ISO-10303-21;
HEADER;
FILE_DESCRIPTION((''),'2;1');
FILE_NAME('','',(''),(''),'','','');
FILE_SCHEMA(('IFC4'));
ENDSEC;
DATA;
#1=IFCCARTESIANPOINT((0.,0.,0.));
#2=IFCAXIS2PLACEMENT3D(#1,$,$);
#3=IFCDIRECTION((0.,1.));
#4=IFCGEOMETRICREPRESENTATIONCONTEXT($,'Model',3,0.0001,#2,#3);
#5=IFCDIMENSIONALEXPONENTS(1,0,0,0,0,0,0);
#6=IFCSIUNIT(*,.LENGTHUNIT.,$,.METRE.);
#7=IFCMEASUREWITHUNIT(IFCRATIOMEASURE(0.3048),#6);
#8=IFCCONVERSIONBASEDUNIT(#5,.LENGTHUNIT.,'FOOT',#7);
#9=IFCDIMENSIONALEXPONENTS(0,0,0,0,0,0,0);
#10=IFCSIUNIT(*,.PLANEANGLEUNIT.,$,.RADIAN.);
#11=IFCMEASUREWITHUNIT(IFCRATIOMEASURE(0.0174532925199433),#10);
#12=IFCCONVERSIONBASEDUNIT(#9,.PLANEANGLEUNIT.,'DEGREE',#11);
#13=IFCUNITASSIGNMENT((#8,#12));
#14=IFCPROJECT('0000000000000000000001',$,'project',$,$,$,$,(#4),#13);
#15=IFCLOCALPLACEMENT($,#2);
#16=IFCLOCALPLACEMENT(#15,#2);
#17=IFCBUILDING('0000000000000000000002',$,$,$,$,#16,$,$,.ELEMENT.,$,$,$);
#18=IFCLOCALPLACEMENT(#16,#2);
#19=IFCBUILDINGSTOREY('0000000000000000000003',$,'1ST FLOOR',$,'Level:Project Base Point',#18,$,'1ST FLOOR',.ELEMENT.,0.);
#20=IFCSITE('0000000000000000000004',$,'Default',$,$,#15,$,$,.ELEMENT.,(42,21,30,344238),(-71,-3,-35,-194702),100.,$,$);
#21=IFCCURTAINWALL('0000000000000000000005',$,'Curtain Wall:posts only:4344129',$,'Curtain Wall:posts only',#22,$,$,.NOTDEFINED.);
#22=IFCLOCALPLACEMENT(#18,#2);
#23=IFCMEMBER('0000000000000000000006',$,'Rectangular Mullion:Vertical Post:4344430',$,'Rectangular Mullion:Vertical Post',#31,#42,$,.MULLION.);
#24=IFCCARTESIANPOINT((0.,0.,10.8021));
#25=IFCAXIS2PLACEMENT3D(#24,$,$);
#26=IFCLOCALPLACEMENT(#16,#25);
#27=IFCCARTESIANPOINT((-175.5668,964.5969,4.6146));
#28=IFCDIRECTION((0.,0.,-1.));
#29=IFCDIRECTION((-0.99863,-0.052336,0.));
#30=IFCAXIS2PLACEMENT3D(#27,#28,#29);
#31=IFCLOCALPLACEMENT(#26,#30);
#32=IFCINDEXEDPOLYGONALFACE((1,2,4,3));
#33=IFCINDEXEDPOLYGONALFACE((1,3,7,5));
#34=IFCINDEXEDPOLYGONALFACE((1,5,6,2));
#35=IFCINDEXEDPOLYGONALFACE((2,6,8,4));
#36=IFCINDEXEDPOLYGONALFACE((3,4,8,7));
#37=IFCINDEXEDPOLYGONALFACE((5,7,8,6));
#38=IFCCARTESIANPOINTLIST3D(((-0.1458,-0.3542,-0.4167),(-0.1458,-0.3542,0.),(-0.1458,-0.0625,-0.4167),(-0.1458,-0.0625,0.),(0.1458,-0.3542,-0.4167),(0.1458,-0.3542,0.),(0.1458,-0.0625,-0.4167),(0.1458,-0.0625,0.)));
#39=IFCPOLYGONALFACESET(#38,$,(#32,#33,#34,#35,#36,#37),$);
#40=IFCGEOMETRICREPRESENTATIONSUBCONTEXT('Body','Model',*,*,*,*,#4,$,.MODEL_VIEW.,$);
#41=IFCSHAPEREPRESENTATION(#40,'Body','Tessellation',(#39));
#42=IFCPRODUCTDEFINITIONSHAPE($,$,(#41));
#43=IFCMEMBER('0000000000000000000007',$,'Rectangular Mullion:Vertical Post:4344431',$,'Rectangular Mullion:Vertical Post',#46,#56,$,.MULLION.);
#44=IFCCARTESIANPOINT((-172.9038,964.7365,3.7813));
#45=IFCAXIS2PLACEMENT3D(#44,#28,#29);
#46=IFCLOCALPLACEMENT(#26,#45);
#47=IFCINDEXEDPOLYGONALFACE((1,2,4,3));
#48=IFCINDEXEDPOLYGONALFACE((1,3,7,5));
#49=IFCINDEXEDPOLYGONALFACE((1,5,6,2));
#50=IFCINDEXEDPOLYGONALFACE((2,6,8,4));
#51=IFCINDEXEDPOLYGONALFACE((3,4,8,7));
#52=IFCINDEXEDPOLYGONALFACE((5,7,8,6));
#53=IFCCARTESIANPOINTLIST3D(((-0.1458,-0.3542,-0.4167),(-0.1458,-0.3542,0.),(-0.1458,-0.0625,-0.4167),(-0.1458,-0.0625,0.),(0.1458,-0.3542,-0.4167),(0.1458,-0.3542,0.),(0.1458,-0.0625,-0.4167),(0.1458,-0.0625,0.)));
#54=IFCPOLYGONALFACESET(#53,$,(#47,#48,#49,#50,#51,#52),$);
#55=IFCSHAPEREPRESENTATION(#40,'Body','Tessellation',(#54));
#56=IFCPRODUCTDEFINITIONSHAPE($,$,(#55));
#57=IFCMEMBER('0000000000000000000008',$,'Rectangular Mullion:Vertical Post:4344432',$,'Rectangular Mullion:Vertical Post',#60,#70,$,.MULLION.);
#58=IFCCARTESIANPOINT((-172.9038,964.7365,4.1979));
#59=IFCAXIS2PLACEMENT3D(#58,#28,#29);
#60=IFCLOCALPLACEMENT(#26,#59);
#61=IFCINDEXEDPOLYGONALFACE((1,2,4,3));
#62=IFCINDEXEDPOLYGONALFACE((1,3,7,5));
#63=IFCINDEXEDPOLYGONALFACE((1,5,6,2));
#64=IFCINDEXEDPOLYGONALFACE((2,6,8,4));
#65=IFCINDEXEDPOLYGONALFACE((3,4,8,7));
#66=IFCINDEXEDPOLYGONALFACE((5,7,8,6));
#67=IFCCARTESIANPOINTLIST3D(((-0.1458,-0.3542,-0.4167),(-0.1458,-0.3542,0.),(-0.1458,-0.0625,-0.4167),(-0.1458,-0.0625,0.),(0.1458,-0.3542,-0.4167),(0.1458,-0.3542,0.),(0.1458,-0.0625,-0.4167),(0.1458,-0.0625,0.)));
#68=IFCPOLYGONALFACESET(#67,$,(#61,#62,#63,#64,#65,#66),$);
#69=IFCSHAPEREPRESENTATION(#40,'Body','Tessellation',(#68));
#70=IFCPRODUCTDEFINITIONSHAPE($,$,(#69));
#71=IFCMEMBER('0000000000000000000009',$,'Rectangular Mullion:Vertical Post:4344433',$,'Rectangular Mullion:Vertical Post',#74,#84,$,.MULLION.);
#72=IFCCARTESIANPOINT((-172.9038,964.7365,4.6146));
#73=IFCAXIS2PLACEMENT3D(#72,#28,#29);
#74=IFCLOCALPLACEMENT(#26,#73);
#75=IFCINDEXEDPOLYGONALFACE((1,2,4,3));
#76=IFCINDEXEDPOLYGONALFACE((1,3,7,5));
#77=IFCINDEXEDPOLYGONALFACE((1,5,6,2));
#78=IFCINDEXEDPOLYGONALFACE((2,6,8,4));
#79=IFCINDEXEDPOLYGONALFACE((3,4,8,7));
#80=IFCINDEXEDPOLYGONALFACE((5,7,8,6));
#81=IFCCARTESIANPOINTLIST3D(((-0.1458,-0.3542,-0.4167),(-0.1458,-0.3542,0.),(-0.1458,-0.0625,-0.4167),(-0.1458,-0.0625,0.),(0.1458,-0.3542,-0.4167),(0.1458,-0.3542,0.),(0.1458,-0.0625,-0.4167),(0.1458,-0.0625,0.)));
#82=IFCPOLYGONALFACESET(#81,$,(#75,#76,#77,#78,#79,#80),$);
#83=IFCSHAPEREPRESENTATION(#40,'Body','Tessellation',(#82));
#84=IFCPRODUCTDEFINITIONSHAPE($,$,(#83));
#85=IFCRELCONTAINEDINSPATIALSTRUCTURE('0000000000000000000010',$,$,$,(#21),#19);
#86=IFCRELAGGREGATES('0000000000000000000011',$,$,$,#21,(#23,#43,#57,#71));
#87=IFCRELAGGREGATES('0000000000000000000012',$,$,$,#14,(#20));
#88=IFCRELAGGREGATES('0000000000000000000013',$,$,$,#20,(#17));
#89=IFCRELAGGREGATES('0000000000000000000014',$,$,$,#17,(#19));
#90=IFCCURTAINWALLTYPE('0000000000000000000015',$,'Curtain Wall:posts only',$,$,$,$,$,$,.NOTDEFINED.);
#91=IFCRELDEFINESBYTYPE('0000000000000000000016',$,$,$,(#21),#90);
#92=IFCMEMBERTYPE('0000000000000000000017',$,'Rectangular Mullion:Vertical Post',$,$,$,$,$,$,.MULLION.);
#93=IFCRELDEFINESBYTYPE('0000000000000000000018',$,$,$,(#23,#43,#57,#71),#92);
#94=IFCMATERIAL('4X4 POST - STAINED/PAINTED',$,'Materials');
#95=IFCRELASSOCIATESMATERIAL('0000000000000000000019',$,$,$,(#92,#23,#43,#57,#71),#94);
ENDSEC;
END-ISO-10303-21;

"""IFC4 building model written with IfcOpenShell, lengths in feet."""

from ifc_helpers import new_model, entity, si_unit, converted_unit, direction, frame, origin, origin_2d_with_axis, place, context, subcontext, project, spatial, rectangle, extrude, source, transform, mapped, material, material_profile, profile_set, profile_usage, type_object, type_shapes, element, aggregate, save


model = new_model("IFC4")

# Units and contexts
model_context = context("Model", 3, precision=0.0001, world=origin(), true_north=direction((0.0, 1.0)))
body_context = subcontext(model_context, "Body", "Model", "MODEL_VIEW")
ifc_project = project(units=[converted_unit("LENGTHUNIT", "FOOT", entity("IfcRatioMeasure", 0.3048), si_unit("LENGTHUNIT", "METRE"), dimensions=[1, 0, 0, 0, 0, 0, 0]), converted_unit("PLANEANGLEUNIT", "DEGREE", entity("IfcRatioMeasure", 0.0174532925199433), si_unit("PLANEANGLEUNIT", "RADIAN"), dimensions=[0, 0, 0, 0, 0, 0, 0])], contexts=[model_context])

# Site, building, storey
site_placement = place(None, origin())
site = spatial("IfcSite", under=ifc_project, at=site_placement, Name="Default", CompositionType="ELEMENT", RefLatitude=(42, 21, 30, 344238), RefLongitude=(-71, -3, -35, -194702), RefElevation=100.0)
building_placement = place(site_placement, origin())
building = spatial("IfcBuilding", under=site, at=building_placement, CompositionType="ELEMENT")
storey_placement = place(building_placement, origin())
storey = spatial("IfcBuildingStorey", under=building, at=storey_placement, Name="1ST FLOOR", ObjectType="Level:Project Base Point", LongName="1ST FLOOR", CompositionType="ELEMENT", Elevation=0.0)

# Curtain wall, members
curtain_wall_type_1 = type_object("IfcCurtainWallType", Name="Curtain Wall:posts only", PredefinedType="NOTDEFINED")
curtain_wall_1_placement = place(storey_placement, origin())
curtain_wall_1 = element("IfcCurtainWall", 1, at=curtain_wall_1_placement, inside=storey, type_object=curtain_wall_type_1, Name="Curtain Wall:posts only:4344129", ObjectType="Curtain Wall:posts only", PredefinedType="NOTDEFINED")
ifc_material_1 = material(Name="4X4 POST - STAINED/PAINTED", Category="Materials")
ifc_material_profile_1 = material_profile(ifc_material_1, rectangle(XDim=0.2917, YDim=0.2917, at=origin_2d_with_axis()), Name="Vertical Post")
ifc_profile_set_1 = profile_set([ifc_material_profile_1], Name="Vertical Post")
ifc_profile_usage_1 = profile_usage(ifc_profile_set_1)
member_type_1 = type_object("IfcMemberType", Name="Rectangular Mullion:Vertical Post", PredefinedType="MULLION", material=ifc_profile_set_1)
shared_shape_1 = source(origin(), body_context, "Body", "SweptSolid", [
    extrude(rectangle(XDim=0.2917, YDim=0.2917, at=origin_2d_with_axis()), frame((0.0, -0.2083, -0.4167), z_axis=(0.0, 0.0, 1.0), x_axis=(0.0, -1.0, 0.0)), (0.0, 0.0, 1.0), 0.4167),
])
type_shapes(member_type_1, [shared_shape_1])
placement = place(building_placement, frame((0.0, 0.0, 10.8021)))
member_1_placement = place(placement, frame((-175.5668, 964.5969, 4.6146), z_axis=(0.0, 0.0, -1.0), x_axis=(-0.99863, -0.052336, 0.0)))
member_1 = element("IfcMember", 2, at=member_1_placement, type_object=member_type_1, material=ifc_profile_usage_1, Name="Rectangular Mullion:Vertical Post:4344430", ObjectType="Rectangular Mullion:Vertical Post", PredefinedType="MULLION", context=body_context, shape_type="MappedRepresentation", body=[
    mapped(shared_shape_1, transform((0.0, 0.0, 0.0), scale=1.0)),
])
ifc_profile_usage_2 = profile_usage(ifc_profile_set_1)
member_2_placement = place(placement, frame((-172.9038, 964.7365, 3.7813), z_axis=(0.0, 0.0, -1.0), x_axis=(-0.99863, -0.052336, 0.0)))
member_2 = element("IfcMember", 3, at=member_2_placement, type_object=member_type_1, material=ifc_profile_usage_2, Name="Rectangular Mullion:Vertical Post:4344431", ObjectType="Rectangular Mullion:Vertical Post", PredefinedType="MULLION", context=body_context, shape_type="MappedRepresentation", body=[
    mapped(shared_shape_1, transform((0.0, 0.0, 0.0), scale=1.0)),
])
ifc_profile_usage_3 = profile_usage(ifc_profile_set_1)
member_3_placement = place(placement, frame((-172.9038, 964.7365, 4.1979), z_axis=(0.0, 0.0, -1.0), x_axis=(-0.99863, -0.052336, 0.0)))
member_3 = element("IfcMember", 4, at=member_3_placement, type_object=member_type_1, material=ifc_profile_usage_3, Name="Rectangular Mullion:Vertical Post:4344432", ObjectType="Rectangular Mullion:Vertical Post", PredefinedType="MULLION", context=body_context, shape_type="MappedRepresentation", body=[
    mapped(shared_shape_1, transform((0.0, 0.0, 0.0), scale=1.0)),
])
ifc_profile_usage_4 = profile_usage(ifc_profile_set_1)
member_4_placement = place(placement, frame((-172.9038, 964.7365, 4.6146), z_axis=(0.0, 0.0, -1.0), x_axis=(-0.99863, -0.052336, 0.0)))
member_4 = element("IfcMember", 5, at=member_4_placement, type_object=member_type_1, material=ifc_profile_usage_4, Name="Rectangular Mullion:Vertical Post:4344433", ObjectType="Rectangular Mullion:Vertical Post", PredefinedType="MULLION", context=body_context, shape_type="MappedRepresentation", body=[
    mapped(shared_shape_1, transform((0.0, 0.0, 0.0), scale=1.0)),
])
aggregate(curtain_wall_1, [member_1, member_2, member_3, member_4])

save(model, "model.ifc")
